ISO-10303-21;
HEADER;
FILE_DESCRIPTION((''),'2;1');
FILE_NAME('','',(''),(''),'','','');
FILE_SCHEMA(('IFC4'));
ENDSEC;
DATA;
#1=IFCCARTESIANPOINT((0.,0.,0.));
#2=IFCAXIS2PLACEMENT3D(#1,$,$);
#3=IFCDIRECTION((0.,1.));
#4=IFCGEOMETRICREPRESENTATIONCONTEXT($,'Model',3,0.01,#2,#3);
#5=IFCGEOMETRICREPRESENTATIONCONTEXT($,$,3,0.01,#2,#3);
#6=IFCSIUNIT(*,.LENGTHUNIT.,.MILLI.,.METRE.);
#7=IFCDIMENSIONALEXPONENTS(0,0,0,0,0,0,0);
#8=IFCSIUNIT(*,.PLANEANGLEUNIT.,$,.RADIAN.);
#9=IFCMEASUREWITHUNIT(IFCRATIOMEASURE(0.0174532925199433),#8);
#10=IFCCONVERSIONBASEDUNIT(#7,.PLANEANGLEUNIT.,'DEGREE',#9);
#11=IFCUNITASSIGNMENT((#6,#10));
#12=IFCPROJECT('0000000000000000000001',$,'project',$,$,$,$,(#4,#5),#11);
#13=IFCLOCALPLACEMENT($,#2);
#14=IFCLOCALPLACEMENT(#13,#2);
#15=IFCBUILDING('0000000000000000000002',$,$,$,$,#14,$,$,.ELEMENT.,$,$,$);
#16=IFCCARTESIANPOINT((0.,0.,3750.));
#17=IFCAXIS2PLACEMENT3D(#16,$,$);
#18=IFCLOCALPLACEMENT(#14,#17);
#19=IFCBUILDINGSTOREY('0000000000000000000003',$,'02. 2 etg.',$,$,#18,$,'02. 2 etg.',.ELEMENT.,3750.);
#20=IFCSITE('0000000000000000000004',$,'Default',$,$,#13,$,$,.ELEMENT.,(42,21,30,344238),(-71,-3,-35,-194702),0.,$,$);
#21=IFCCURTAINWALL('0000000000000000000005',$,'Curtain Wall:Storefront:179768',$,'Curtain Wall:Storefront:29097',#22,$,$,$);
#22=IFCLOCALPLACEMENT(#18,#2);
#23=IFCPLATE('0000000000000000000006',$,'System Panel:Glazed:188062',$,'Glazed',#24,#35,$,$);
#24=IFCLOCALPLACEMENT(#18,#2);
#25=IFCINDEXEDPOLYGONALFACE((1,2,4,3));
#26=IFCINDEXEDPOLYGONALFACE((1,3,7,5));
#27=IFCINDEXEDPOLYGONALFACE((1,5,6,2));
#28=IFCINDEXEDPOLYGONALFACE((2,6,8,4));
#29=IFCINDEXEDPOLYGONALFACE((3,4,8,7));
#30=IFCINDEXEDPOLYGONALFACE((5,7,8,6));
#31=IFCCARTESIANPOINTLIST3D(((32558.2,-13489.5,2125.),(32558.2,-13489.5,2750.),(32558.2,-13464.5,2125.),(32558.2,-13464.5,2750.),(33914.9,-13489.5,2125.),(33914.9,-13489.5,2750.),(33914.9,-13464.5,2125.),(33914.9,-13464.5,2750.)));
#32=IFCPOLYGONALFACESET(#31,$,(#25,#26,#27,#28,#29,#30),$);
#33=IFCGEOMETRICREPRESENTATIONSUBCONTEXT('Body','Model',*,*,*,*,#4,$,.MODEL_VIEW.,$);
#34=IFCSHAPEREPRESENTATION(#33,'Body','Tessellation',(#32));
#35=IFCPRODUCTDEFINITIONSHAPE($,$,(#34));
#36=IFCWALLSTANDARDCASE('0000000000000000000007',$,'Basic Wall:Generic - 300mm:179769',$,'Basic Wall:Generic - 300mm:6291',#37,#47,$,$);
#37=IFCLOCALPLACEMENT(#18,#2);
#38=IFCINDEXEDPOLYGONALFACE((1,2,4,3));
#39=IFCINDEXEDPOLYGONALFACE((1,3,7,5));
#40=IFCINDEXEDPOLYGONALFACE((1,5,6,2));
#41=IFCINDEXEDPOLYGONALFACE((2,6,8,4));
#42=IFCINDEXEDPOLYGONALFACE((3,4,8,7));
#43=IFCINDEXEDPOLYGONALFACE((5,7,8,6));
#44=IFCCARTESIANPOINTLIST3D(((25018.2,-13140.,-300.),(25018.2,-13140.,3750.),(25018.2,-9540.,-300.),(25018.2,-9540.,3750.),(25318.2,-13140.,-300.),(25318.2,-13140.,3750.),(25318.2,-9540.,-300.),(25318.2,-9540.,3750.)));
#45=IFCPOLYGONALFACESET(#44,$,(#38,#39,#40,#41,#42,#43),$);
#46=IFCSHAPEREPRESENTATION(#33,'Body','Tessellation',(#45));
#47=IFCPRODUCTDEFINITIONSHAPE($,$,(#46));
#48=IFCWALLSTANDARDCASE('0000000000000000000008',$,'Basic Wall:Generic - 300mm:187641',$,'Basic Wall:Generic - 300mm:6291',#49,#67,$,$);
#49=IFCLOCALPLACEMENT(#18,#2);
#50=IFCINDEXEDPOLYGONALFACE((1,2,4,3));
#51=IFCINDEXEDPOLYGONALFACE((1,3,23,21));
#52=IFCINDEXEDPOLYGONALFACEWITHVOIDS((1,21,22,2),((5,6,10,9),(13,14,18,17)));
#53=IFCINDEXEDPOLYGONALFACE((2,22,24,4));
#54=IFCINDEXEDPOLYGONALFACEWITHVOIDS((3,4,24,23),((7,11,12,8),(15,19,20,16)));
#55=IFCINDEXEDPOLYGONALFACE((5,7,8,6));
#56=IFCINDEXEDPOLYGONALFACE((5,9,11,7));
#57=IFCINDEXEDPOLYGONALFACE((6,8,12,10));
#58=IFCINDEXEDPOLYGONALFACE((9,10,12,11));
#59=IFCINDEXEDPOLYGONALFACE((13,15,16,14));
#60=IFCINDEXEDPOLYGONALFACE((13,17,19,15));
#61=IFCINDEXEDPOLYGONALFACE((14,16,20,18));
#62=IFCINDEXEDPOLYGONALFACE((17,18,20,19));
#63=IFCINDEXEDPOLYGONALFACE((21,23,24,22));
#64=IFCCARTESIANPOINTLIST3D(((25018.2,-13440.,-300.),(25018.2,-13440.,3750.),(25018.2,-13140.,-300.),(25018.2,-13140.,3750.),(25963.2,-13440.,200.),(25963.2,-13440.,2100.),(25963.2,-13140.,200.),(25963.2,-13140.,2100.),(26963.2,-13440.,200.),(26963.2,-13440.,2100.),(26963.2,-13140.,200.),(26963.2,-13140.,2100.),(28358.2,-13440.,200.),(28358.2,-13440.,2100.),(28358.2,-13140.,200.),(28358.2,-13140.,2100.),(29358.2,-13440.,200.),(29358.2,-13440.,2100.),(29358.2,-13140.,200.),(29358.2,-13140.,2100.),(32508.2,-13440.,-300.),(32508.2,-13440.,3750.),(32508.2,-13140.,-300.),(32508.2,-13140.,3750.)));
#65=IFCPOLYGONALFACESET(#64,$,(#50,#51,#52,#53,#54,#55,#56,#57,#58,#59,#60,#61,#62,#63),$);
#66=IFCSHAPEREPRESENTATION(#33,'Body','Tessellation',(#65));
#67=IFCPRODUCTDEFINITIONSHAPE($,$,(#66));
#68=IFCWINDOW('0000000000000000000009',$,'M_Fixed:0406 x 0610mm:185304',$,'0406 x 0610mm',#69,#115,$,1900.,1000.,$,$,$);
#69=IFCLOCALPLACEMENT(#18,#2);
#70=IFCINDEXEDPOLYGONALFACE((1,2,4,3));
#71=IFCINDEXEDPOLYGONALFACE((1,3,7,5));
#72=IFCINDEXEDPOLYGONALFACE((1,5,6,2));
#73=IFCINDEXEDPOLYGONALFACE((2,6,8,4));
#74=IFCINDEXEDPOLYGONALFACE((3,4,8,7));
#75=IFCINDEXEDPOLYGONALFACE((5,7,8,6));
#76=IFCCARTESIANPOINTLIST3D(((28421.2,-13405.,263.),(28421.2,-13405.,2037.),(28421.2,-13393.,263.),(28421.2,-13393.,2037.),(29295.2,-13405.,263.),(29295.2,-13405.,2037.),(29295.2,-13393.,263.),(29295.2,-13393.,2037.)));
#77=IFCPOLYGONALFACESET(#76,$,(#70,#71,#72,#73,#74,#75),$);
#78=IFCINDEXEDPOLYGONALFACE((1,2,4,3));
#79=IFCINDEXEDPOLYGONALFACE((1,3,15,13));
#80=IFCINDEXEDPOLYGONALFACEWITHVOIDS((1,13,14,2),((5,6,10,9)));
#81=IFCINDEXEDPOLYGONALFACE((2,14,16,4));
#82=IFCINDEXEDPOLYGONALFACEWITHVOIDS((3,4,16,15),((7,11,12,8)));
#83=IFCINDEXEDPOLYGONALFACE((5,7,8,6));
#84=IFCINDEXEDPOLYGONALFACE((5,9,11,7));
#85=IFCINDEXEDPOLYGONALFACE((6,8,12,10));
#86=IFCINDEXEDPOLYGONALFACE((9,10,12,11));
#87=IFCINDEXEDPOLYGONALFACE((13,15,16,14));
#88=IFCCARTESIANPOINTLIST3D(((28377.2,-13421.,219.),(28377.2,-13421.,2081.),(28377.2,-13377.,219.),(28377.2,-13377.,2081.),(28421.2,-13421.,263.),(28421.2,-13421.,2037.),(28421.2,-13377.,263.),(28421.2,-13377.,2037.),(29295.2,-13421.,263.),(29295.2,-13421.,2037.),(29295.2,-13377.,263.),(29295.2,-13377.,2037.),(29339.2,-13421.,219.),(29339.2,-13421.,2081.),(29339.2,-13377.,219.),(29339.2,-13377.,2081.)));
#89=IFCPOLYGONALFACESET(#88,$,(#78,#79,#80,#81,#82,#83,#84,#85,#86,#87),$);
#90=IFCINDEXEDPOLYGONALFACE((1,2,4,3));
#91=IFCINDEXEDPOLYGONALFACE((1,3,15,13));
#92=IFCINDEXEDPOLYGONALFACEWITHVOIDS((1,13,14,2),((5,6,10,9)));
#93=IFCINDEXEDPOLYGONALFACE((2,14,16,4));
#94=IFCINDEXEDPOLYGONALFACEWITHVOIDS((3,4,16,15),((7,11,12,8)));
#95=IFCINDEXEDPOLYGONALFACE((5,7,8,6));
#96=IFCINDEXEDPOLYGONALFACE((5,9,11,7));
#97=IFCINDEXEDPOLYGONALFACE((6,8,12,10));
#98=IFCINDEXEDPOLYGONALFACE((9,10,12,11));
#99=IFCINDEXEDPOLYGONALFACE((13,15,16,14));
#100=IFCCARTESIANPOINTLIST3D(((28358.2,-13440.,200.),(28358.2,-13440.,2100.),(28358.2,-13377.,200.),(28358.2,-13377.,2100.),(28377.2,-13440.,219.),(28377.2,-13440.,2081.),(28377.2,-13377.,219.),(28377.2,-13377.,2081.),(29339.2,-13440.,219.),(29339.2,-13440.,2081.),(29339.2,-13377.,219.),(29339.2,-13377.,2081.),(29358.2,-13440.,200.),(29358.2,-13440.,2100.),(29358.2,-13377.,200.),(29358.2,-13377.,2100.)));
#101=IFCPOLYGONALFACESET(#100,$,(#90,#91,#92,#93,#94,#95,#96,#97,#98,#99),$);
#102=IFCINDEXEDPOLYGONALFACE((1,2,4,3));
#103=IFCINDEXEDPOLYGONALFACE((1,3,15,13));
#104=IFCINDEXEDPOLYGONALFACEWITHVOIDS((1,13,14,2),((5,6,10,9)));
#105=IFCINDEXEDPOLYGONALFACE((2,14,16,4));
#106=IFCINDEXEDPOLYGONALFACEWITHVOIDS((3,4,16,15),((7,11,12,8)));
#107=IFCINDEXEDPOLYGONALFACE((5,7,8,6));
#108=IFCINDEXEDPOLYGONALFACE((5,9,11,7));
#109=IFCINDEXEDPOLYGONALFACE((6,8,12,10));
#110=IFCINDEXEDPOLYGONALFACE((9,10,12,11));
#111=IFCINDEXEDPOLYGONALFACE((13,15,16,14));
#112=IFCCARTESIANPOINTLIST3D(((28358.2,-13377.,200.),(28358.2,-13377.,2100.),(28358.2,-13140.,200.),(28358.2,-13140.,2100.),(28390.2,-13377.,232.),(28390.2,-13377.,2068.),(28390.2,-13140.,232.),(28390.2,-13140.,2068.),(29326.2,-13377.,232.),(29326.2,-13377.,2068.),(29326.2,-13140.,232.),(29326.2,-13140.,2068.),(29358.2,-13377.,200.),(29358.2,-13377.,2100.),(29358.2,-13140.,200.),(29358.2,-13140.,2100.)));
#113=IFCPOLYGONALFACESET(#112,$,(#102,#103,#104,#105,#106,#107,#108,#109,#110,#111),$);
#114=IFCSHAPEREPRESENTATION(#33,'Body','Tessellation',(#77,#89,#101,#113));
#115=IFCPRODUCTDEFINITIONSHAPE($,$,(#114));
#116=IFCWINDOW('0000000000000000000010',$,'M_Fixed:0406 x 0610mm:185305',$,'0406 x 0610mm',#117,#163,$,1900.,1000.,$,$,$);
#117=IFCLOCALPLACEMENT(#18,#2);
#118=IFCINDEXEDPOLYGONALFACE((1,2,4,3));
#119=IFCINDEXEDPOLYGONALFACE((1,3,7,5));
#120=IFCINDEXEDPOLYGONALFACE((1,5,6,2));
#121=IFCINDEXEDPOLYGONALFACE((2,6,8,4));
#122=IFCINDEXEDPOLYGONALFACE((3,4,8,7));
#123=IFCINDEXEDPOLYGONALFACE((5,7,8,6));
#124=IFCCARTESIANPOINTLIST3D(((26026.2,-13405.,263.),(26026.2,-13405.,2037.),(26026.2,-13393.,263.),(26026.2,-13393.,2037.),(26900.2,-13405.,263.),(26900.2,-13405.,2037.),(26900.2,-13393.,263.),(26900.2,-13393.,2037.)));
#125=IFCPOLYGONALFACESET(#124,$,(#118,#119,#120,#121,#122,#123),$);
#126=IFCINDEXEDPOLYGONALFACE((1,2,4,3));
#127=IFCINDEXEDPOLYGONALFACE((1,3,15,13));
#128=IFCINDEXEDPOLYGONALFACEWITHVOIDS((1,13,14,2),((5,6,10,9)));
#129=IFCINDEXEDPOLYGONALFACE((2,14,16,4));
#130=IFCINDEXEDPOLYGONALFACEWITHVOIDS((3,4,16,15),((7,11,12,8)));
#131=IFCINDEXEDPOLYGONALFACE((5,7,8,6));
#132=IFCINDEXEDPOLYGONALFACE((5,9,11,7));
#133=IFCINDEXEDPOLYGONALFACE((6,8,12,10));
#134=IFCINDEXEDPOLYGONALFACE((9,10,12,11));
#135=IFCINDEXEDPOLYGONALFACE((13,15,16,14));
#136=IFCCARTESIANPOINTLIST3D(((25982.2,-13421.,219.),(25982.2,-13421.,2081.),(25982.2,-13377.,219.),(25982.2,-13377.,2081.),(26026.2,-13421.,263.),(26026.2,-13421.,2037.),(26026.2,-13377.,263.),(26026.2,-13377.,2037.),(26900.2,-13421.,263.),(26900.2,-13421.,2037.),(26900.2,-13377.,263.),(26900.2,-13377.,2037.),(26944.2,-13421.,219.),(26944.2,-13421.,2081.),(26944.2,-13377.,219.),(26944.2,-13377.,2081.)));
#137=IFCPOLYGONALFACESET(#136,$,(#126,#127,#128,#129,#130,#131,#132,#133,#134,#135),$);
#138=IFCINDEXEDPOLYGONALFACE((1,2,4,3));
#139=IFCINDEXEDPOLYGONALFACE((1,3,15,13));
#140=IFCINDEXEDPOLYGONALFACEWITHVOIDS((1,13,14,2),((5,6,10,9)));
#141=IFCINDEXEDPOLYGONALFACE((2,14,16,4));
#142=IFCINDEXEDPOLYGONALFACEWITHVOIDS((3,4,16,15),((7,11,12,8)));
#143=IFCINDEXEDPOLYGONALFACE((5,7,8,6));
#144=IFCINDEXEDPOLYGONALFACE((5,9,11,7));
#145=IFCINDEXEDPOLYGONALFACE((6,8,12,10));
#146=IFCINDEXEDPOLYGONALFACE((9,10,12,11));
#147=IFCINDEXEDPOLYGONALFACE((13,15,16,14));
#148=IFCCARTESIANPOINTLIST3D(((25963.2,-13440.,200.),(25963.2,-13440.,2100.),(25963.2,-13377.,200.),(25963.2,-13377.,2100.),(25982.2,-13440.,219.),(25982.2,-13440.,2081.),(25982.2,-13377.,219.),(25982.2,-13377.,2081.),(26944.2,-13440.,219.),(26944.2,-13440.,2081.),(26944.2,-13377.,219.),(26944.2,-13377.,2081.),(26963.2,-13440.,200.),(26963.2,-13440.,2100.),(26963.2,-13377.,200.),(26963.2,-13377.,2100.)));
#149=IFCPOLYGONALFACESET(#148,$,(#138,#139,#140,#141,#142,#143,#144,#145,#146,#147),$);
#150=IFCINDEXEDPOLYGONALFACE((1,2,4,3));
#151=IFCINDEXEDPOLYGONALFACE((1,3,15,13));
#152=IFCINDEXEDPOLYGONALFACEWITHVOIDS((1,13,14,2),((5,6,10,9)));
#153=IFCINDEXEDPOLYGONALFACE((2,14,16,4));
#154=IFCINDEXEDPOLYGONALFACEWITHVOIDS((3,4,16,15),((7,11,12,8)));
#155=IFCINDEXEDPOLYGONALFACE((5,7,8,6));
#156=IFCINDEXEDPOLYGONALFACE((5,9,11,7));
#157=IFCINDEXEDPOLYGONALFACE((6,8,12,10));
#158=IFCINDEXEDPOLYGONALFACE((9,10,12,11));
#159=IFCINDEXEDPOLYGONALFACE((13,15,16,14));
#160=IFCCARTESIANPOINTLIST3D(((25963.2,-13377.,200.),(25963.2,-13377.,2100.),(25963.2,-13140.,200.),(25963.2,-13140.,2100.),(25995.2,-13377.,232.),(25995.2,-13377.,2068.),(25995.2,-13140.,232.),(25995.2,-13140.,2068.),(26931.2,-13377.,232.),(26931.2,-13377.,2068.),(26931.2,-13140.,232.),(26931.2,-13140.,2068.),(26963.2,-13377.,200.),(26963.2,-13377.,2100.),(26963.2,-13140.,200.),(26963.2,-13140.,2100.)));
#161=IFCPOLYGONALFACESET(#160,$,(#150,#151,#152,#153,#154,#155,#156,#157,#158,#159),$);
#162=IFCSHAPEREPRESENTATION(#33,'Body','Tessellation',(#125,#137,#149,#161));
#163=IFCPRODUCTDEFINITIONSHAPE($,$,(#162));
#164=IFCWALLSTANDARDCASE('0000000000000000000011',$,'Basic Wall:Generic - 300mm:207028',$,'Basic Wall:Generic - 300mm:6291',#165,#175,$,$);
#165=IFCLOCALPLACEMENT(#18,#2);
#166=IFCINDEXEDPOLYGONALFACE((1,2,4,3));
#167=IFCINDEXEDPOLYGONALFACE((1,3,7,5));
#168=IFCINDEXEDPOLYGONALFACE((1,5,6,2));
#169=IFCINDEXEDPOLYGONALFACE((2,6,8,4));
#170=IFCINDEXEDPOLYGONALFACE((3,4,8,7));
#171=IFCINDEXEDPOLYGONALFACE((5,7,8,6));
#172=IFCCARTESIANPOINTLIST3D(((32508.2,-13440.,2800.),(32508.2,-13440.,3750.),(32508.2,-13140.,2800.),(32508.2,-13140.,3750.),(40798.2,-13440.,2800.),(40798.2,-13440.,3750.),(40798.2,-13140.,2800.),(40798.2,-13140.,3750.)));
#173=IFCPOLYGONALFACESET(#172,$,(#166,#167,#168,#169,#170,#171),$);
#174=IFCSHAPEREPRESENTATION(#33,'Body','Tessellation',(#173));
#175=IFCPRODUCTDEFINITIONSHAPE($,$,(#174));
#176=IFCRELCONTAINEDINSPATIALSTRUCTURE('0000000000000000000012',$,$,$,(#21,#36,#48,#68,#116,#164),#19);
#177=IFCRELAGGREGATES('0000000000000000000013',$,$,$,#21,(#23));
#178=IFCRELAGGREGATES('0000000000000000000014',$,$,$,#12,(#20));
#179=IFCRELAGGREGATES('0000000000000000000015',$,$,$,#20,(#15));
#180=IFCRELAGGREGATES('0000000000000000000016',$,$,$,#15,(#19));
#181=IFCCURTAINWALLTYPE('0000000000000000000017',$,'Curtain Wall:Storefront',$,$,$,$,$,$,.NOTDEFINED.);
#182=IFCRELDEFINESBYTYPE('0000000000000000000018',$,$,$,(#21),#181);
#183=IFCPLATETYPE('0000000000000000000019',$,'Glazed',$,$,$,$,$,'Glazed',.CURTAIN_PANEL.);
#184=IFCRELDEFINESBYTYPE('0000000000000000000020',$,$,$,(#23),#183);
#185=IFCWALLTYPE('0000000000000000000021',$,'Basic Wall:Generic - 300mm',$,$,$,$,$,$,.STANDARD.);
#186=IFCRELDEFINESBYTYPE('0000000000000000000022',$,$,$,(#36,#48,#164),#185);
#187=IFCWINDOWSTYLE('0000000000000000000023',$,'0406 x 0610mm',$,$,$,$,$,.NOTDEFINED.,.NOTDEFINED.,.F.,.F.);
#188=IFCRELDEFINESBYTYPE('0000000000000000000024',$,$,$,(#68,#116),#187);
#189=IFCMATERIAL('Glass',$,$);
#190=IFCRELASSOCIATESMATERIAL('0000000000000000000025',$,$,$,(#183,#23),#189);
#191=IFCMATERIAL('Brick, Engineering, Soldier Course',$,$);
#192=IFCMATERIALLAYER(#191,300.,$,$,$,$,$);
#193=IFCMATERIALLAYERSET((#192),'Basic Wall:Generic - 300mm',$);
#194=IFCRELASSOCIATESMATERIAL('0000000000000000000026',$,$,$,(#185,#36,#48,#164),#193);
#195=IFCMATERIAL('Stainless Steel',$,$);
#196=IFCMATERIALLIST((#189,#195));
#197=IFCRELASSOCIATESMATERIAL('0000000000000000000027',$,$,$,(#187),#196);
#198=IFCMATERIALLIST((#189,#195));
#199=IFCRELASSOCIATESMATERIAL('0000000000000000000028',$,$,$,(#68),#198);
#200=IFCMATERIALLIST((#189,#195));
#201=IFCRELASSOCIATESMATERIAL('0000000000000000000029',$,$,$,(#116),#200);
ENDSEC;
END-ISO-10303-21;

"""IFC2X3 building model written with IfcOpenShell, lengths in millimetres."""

from ifc_helpers import new_model, entity, si_unit, converted_unit, direction, frame, frame_2d, origin, origin_2d_with_axis, place, context, subcontext, project, spatial, polyline, rectangle, outline, extrude, source, transform, mapped, material, material_list, layer, layer_set, layer_usage, type_object, type_shapes, element, fill, aggregate, save


model = new_model("IFC2X3")

# Units and contexts
model_context = context("Model", 3, precision=0.01, world=origin(), true_north=direction((0.0, 1.0)))
context_of_model = context(None, 3, precision=0.01, world=origin(), true_north=direction((0.0, 1.0)))
body_context = subcontext(model_context, "Body", "Model", "MODEL_VIEW")
ifc_project = project(units=[si_unit("LENGTHUNIT", "METRE", prefix="MILLI"), converted_unit("PLANEANGLEUNIT", "DEGREE", entity("IfcRatioMeasure", 0.0174532925199433), si_unit("PLANEANGLEUNIT", "RADIAN"), dimensions=[0, 0, 0, 0, 0, 0, 0])], contexts=[model_context, context_of_model])

# Site, building, storey
site_placement = place(None, origin())
site = spatial("IfcSite", under=ifc_project, at=site_placement, Name="Default", CompositionType="ELEMENT", RefLatitude=(42, 21, 30, 344238), RefLongitude=(-71, -3, -35, -194702), RefElevation=0.0)
building_placement = place(site_placement, origin())
building = spatial("IfcBuilding", under=site, at=building_placement, CompositionType="ELEMENT")
storey_placement = place(building_placement, frame((0.0, 0.0, 3750.0)))
storey = spatial("IfcBuildingStorey", under=building, at=storey_placement, Name="02. 2 etg.", LongName="02. 2 etg.", CompositionType="ELEMENT", Elevation=3750.0)

# Curtain wall, plate
curtain_wall_type = type_object("IfcCurtainWallType", Name="Curtain Wall:Storefront", PredefinedType="NOTDEFINED")
curtain_wall_placement = place(storey_placement, frame((0.0, 0.0, -3750.0)))
curtain_wall = element("IfcCurtainWall", 1, at=curtain_wall_placement, inside=storey, type_object=curtain_wall_type, Name="Curtain Wall:Storefront:179768", ObjectType="Curtain Wall:Storefront:29097")
ifc_material_1 = material(Name="Glass")
plate_type_1 = type_object("IfcPlateType", Name="Glazed", ElementType="Glazed", PredefinedType="CURTAIN_PANEL", material=ifc_material_1)
shared_shape_1 = source(origin(), body_context, "Body", "SweptSolid", [
    extrude(rectangle(XDim=25.0, YDim=1356.7, at=origin_2d_with_axis()), frame((678.3, 12.5, 0.0), z_axis=(0.0, 0.0, 1.0), x_axis=(0.0, 1.0, 0.0)), (0.0, 0.0, 1.0), 625.0),
])
type_shapes(plate_type_1, [shared_shape_1])
plate_1_placement = place(curtain_wall_placement, frame((33914.9, -13464.5, 5875.0), z_axis=(0.0, 0.0, 1.0), x_axis=(-1.0, 0.0, 0.0)))
plate_1 = element("IfcPlate", 2, at=plate_1_placement, type_object=plate_type_1, material=ifc_material_1, Name="System Panel:Glazed:188062", ObjectType="Glazed", context=body_context, shape_type="MappedRepresentation", body=[
    mapped(shared_shape_1, transform((0.0, 0.0, 0.0), scale=1.0)),
])
aggregate(curtain_wall, [plate_1])

# Wall
ifc_material_2 = material(Name="Brick, Engineering, Soldier Course")
ifc_layer_1 = layer(ifc_material_2, 300.0)
ifc_layer_set_1 = layer_set([ifc_layer_1], Name="Basic Wall:Generic - 300mm")
ifc_layer_usage_1 = layer_usage(ifc_layer_set_1, "AXIS2", "NEGATIVE", 150.0)
wall_type_1 = type_object("IfcWallType", Name="Basic Wall:Generic - 300mm", PredefinedType="STANDARD", material=ifc_layer_set_1)
wall_1_placement = place(storey_placement, frame((25168.2, -13140.0, -300.0), z_axis=(0.0, 0.0, 1.0), x_axis=(0.0, 1.0, 0.0)))
element("IfcWallStandardCase", 3, at=wall_1_placement, inside=storey, type_object=wall_type_1, material=ifc_layer_usage_1, Name="Basic Wall:Generic - 300mm:179769", ObjectType="Basic Wall:Generic - 300mm:6291", context=body_context, shape_type="SweptSolid", body=[
    extrude(rectangle(XDim=3600.0, YDim=300.0, at=frame_2d((1800.0, 0.0), x_axis=(-1.0, 0.0))), origin(), (0.0, 0.0, 1.0), 4050.0),
])

# Wall, openings, windows
ifc_layer_usage_2 = layer_usage(ifc_layer_set_1, "AXIS2", "NEGATIVE", 150.0)
wall_2_placement = place(storey_placement, frame((32508.2, -13290.0, -300.0), z_axis=(0.0, 0.0, 1.0), x_axis=(-1.0, 0.0, 0.0)))
wall_2 = element("IfcWallStandardCase", 4, at=wall_2_placement, inside=storey, type_object=wall_type_1, material=ifc_layer_usage_2, Name="Basic Wall:Generic - 300mm:187641", ObjectType="Basic Wall:Generic - 300mm:6291", context=body_context, shape_type="SweptSolid", body=[
    extrude(rectangle(XDim=7490.0, YDim=300.0, at=frame_2d((3745.0, 0.0), x_axis=(-1.0, 0.0))), origin(), (0.0, 0.0, 1.0), 4050.0),
])
opening_1_placement = place(wall_2_placement, frame((3150.0, -150.0, 500.0)))
opening_1 = element("IfcOpeningElement", 5, at=opening_1_placement, cuts=wall_2, ObjectType="Opening", context=body_context, shape_type="SweptSolid", body=[
    extrude(rectangle(XDim=1900.0, YDim=1000.0, at=frame_2d((950.0, 500.0), x_axis=(1.0, 0.0))), frame((0.0, 0.0, 0.0), z_axis=(0.0, 1.0, 0.0), x_axis=(0.0, 0.0, 1.0)), (0.0, 0.0, 1.0), 300.0),
])
opening_2_placement = place(wall_2_placement, frame((5545.0, -150.0, 500.0)))
opening_2 = element("IfcOpeningElement", 6, at=opening_2_placement, cuts=wall_2, ObjectType="Opening", context=body_context, shape_type="SweptSolid", body=[
    extrude(rectangle(XDim=1900.0, YDim=1000.0, at=frame_2d((950.0, 500.0), x_axis=(1.0, 0.0))), frame((0.0, 0.0, 0.0), z_axis=(0.0, 1.0, 0.0), x_axis=(0.0, 0.0, 1.0)), (0.0, 0.0, 1.0), 300.0),
])
ifc_material_3 = material(Name="Stainless Steel")
ifc_material_list_1 = material_list([ifc_material_1, ifc_material_3])
ifc_material_list_2 = material_list([ifc_material_1, ifc_material_3])
window_style = type_object("IfcWindowStyle", Name="0406 x 0610mm", ConstructionType="NOTDEFINED", OperationType="NOTDEFINED", ParameterTakesPrecedence=False, Sizeable=False, material=ifc_material_list_2)
shared_shape_2 = source(origin(), body_context, "Body", "SweptSolid", [
    extrude(rectangle(XDim=874.0, YDim=12.0, at=frame_2d((0.0, 0.0), x_axis=(1.0, 0.0))), frame((500.0, 285.0, 63.0), z_axis=(0.0, 0.0, 1.0), x_axis=(-1.0, 0.0, 0.0)), (0.0, 0.0, 1.0), 1774.0),
    extrude(outline(polyline([(-481.0, -931.0), (481.0, -931.0), (481.0, 931.0), (-481.0, 931.0), (-481.0, -931.0)]), holes=[polyline([(-437.0, -887.0), (-437.0, 887.0), (437.0, 887.0), (437.0, -887.0), (-437.0, -887.0)])]), frame((500.0, 307.0, 950.0), z_axis=(0.0, -1.0, 0.0), x_axis=(-1.0, 0.0, 0.0)), (0.0, 0.0, 1.0), 44.0),
    extrude(outline(polyline([(-500.0, -950.0), (500.0, -950.0), (500.0, 950.0), (-500.0, 950.0), (-500.0, -950.0)]), holes=[polyline([(-481.0, -931.0), (-481.0, 931.0), (481.0, 931.0), (481.0, -931.0), (-481.0, -931.0)])]), frame((500.0, 326.0, 950.0), z_axis=(0.0, -1.0, 0.0), x_axis=(-1.0, 0.0, 0.0)), (0.0, 0.0, 1.0), 63.0),
    extrude(outline(polyline([(-500.0, -950.0), (500.0, -950.0), (500.0, 950.0), (-500.0, 950.0), (-500.0, -950.0)]), holes=[polyline([(-468.0, -918.0), (-468.0, 918.0), (468.0, 918.0), (468.0, -918.0), (-468.0, -918.0)])]), frame((500.0, 263.0, 950.0), z_axis=(0.0, -1.0, 0.0), x_axis=(-1.0, 0.0, 0.0)), (0.0, 0.0, 1.0), 237.0),
])
type_shapes(window_style, [shared_shape_2])
window_1_placement = place(opening_1_placement, frame((0.0, -26.0, 0.0)))
window_1 = element("IfcWindow", 7, at=window_1_placement, inside=storey, type_object=window_style, material=ifc_material_list_1, Name="M_Fixed:0406 x 0610mm:185304", ObjectType="0406 x 0610mm", OverallHeight=1900.0, OverallWidth=1000.0, context=body_context, shape_type="MappedRepresentation", body=[
    mapped(shared_shape_2, transform((0.0, 0.0, 0.0), scale=1.0)),
])
fill(opening_1, window_1)
ifc_material_list_3 = material_list([ifc_material_1, ifc_material_3])
window_2_placement = place(opening_2_placement, frame((0.0, -26.0, 0.0)))
window_2 = element("IfcWindow", 8, at=window_2_placement, inside=storey, type_object=window_style, material=ifc_material_list_3, Name="M_Fixed:0406 x 0610mm:185305", ObjectType="0406 x 0610mm", OverallHeight=1900.0, OverallWidth=1000.0, context=body_context, shape_type="MappedRepresentation", body=[
    mapped(shared_shape_2, transform((0.0, 0.0, 0.0), scale=1.0)),
])
fill(opening_2, window_2)

# Wall
ifc_layer_usage_3 = layer_usage(ifc_layer_set_1, "AXIS2", "NEGATIVE", 150.0)
wall_3_placement = place(storey_placement, frame((32508.2, -13290.0, 2800.0)))
element("IfcWallStandardCase", 9, at=wall_3_placement, inside=storey, type_object=wall_type_1, material=ifc_layer_usage_3, Name="Basic Wall:Generic - 300mm:207028", ObjectType="Basic Wall:Generic - 300mm:6291", context=body_context, shape_type="SweptSolid", body=[
    extrude(rectangle(XDim=8290.0, YDim=300.0, at=frame_2d((4145.0, 0.0), x_axis=(-1.0, 0.0))), origin(), (0.0, 0.0, 1.0), 950.0),
])

save(model, "model.ifc")
